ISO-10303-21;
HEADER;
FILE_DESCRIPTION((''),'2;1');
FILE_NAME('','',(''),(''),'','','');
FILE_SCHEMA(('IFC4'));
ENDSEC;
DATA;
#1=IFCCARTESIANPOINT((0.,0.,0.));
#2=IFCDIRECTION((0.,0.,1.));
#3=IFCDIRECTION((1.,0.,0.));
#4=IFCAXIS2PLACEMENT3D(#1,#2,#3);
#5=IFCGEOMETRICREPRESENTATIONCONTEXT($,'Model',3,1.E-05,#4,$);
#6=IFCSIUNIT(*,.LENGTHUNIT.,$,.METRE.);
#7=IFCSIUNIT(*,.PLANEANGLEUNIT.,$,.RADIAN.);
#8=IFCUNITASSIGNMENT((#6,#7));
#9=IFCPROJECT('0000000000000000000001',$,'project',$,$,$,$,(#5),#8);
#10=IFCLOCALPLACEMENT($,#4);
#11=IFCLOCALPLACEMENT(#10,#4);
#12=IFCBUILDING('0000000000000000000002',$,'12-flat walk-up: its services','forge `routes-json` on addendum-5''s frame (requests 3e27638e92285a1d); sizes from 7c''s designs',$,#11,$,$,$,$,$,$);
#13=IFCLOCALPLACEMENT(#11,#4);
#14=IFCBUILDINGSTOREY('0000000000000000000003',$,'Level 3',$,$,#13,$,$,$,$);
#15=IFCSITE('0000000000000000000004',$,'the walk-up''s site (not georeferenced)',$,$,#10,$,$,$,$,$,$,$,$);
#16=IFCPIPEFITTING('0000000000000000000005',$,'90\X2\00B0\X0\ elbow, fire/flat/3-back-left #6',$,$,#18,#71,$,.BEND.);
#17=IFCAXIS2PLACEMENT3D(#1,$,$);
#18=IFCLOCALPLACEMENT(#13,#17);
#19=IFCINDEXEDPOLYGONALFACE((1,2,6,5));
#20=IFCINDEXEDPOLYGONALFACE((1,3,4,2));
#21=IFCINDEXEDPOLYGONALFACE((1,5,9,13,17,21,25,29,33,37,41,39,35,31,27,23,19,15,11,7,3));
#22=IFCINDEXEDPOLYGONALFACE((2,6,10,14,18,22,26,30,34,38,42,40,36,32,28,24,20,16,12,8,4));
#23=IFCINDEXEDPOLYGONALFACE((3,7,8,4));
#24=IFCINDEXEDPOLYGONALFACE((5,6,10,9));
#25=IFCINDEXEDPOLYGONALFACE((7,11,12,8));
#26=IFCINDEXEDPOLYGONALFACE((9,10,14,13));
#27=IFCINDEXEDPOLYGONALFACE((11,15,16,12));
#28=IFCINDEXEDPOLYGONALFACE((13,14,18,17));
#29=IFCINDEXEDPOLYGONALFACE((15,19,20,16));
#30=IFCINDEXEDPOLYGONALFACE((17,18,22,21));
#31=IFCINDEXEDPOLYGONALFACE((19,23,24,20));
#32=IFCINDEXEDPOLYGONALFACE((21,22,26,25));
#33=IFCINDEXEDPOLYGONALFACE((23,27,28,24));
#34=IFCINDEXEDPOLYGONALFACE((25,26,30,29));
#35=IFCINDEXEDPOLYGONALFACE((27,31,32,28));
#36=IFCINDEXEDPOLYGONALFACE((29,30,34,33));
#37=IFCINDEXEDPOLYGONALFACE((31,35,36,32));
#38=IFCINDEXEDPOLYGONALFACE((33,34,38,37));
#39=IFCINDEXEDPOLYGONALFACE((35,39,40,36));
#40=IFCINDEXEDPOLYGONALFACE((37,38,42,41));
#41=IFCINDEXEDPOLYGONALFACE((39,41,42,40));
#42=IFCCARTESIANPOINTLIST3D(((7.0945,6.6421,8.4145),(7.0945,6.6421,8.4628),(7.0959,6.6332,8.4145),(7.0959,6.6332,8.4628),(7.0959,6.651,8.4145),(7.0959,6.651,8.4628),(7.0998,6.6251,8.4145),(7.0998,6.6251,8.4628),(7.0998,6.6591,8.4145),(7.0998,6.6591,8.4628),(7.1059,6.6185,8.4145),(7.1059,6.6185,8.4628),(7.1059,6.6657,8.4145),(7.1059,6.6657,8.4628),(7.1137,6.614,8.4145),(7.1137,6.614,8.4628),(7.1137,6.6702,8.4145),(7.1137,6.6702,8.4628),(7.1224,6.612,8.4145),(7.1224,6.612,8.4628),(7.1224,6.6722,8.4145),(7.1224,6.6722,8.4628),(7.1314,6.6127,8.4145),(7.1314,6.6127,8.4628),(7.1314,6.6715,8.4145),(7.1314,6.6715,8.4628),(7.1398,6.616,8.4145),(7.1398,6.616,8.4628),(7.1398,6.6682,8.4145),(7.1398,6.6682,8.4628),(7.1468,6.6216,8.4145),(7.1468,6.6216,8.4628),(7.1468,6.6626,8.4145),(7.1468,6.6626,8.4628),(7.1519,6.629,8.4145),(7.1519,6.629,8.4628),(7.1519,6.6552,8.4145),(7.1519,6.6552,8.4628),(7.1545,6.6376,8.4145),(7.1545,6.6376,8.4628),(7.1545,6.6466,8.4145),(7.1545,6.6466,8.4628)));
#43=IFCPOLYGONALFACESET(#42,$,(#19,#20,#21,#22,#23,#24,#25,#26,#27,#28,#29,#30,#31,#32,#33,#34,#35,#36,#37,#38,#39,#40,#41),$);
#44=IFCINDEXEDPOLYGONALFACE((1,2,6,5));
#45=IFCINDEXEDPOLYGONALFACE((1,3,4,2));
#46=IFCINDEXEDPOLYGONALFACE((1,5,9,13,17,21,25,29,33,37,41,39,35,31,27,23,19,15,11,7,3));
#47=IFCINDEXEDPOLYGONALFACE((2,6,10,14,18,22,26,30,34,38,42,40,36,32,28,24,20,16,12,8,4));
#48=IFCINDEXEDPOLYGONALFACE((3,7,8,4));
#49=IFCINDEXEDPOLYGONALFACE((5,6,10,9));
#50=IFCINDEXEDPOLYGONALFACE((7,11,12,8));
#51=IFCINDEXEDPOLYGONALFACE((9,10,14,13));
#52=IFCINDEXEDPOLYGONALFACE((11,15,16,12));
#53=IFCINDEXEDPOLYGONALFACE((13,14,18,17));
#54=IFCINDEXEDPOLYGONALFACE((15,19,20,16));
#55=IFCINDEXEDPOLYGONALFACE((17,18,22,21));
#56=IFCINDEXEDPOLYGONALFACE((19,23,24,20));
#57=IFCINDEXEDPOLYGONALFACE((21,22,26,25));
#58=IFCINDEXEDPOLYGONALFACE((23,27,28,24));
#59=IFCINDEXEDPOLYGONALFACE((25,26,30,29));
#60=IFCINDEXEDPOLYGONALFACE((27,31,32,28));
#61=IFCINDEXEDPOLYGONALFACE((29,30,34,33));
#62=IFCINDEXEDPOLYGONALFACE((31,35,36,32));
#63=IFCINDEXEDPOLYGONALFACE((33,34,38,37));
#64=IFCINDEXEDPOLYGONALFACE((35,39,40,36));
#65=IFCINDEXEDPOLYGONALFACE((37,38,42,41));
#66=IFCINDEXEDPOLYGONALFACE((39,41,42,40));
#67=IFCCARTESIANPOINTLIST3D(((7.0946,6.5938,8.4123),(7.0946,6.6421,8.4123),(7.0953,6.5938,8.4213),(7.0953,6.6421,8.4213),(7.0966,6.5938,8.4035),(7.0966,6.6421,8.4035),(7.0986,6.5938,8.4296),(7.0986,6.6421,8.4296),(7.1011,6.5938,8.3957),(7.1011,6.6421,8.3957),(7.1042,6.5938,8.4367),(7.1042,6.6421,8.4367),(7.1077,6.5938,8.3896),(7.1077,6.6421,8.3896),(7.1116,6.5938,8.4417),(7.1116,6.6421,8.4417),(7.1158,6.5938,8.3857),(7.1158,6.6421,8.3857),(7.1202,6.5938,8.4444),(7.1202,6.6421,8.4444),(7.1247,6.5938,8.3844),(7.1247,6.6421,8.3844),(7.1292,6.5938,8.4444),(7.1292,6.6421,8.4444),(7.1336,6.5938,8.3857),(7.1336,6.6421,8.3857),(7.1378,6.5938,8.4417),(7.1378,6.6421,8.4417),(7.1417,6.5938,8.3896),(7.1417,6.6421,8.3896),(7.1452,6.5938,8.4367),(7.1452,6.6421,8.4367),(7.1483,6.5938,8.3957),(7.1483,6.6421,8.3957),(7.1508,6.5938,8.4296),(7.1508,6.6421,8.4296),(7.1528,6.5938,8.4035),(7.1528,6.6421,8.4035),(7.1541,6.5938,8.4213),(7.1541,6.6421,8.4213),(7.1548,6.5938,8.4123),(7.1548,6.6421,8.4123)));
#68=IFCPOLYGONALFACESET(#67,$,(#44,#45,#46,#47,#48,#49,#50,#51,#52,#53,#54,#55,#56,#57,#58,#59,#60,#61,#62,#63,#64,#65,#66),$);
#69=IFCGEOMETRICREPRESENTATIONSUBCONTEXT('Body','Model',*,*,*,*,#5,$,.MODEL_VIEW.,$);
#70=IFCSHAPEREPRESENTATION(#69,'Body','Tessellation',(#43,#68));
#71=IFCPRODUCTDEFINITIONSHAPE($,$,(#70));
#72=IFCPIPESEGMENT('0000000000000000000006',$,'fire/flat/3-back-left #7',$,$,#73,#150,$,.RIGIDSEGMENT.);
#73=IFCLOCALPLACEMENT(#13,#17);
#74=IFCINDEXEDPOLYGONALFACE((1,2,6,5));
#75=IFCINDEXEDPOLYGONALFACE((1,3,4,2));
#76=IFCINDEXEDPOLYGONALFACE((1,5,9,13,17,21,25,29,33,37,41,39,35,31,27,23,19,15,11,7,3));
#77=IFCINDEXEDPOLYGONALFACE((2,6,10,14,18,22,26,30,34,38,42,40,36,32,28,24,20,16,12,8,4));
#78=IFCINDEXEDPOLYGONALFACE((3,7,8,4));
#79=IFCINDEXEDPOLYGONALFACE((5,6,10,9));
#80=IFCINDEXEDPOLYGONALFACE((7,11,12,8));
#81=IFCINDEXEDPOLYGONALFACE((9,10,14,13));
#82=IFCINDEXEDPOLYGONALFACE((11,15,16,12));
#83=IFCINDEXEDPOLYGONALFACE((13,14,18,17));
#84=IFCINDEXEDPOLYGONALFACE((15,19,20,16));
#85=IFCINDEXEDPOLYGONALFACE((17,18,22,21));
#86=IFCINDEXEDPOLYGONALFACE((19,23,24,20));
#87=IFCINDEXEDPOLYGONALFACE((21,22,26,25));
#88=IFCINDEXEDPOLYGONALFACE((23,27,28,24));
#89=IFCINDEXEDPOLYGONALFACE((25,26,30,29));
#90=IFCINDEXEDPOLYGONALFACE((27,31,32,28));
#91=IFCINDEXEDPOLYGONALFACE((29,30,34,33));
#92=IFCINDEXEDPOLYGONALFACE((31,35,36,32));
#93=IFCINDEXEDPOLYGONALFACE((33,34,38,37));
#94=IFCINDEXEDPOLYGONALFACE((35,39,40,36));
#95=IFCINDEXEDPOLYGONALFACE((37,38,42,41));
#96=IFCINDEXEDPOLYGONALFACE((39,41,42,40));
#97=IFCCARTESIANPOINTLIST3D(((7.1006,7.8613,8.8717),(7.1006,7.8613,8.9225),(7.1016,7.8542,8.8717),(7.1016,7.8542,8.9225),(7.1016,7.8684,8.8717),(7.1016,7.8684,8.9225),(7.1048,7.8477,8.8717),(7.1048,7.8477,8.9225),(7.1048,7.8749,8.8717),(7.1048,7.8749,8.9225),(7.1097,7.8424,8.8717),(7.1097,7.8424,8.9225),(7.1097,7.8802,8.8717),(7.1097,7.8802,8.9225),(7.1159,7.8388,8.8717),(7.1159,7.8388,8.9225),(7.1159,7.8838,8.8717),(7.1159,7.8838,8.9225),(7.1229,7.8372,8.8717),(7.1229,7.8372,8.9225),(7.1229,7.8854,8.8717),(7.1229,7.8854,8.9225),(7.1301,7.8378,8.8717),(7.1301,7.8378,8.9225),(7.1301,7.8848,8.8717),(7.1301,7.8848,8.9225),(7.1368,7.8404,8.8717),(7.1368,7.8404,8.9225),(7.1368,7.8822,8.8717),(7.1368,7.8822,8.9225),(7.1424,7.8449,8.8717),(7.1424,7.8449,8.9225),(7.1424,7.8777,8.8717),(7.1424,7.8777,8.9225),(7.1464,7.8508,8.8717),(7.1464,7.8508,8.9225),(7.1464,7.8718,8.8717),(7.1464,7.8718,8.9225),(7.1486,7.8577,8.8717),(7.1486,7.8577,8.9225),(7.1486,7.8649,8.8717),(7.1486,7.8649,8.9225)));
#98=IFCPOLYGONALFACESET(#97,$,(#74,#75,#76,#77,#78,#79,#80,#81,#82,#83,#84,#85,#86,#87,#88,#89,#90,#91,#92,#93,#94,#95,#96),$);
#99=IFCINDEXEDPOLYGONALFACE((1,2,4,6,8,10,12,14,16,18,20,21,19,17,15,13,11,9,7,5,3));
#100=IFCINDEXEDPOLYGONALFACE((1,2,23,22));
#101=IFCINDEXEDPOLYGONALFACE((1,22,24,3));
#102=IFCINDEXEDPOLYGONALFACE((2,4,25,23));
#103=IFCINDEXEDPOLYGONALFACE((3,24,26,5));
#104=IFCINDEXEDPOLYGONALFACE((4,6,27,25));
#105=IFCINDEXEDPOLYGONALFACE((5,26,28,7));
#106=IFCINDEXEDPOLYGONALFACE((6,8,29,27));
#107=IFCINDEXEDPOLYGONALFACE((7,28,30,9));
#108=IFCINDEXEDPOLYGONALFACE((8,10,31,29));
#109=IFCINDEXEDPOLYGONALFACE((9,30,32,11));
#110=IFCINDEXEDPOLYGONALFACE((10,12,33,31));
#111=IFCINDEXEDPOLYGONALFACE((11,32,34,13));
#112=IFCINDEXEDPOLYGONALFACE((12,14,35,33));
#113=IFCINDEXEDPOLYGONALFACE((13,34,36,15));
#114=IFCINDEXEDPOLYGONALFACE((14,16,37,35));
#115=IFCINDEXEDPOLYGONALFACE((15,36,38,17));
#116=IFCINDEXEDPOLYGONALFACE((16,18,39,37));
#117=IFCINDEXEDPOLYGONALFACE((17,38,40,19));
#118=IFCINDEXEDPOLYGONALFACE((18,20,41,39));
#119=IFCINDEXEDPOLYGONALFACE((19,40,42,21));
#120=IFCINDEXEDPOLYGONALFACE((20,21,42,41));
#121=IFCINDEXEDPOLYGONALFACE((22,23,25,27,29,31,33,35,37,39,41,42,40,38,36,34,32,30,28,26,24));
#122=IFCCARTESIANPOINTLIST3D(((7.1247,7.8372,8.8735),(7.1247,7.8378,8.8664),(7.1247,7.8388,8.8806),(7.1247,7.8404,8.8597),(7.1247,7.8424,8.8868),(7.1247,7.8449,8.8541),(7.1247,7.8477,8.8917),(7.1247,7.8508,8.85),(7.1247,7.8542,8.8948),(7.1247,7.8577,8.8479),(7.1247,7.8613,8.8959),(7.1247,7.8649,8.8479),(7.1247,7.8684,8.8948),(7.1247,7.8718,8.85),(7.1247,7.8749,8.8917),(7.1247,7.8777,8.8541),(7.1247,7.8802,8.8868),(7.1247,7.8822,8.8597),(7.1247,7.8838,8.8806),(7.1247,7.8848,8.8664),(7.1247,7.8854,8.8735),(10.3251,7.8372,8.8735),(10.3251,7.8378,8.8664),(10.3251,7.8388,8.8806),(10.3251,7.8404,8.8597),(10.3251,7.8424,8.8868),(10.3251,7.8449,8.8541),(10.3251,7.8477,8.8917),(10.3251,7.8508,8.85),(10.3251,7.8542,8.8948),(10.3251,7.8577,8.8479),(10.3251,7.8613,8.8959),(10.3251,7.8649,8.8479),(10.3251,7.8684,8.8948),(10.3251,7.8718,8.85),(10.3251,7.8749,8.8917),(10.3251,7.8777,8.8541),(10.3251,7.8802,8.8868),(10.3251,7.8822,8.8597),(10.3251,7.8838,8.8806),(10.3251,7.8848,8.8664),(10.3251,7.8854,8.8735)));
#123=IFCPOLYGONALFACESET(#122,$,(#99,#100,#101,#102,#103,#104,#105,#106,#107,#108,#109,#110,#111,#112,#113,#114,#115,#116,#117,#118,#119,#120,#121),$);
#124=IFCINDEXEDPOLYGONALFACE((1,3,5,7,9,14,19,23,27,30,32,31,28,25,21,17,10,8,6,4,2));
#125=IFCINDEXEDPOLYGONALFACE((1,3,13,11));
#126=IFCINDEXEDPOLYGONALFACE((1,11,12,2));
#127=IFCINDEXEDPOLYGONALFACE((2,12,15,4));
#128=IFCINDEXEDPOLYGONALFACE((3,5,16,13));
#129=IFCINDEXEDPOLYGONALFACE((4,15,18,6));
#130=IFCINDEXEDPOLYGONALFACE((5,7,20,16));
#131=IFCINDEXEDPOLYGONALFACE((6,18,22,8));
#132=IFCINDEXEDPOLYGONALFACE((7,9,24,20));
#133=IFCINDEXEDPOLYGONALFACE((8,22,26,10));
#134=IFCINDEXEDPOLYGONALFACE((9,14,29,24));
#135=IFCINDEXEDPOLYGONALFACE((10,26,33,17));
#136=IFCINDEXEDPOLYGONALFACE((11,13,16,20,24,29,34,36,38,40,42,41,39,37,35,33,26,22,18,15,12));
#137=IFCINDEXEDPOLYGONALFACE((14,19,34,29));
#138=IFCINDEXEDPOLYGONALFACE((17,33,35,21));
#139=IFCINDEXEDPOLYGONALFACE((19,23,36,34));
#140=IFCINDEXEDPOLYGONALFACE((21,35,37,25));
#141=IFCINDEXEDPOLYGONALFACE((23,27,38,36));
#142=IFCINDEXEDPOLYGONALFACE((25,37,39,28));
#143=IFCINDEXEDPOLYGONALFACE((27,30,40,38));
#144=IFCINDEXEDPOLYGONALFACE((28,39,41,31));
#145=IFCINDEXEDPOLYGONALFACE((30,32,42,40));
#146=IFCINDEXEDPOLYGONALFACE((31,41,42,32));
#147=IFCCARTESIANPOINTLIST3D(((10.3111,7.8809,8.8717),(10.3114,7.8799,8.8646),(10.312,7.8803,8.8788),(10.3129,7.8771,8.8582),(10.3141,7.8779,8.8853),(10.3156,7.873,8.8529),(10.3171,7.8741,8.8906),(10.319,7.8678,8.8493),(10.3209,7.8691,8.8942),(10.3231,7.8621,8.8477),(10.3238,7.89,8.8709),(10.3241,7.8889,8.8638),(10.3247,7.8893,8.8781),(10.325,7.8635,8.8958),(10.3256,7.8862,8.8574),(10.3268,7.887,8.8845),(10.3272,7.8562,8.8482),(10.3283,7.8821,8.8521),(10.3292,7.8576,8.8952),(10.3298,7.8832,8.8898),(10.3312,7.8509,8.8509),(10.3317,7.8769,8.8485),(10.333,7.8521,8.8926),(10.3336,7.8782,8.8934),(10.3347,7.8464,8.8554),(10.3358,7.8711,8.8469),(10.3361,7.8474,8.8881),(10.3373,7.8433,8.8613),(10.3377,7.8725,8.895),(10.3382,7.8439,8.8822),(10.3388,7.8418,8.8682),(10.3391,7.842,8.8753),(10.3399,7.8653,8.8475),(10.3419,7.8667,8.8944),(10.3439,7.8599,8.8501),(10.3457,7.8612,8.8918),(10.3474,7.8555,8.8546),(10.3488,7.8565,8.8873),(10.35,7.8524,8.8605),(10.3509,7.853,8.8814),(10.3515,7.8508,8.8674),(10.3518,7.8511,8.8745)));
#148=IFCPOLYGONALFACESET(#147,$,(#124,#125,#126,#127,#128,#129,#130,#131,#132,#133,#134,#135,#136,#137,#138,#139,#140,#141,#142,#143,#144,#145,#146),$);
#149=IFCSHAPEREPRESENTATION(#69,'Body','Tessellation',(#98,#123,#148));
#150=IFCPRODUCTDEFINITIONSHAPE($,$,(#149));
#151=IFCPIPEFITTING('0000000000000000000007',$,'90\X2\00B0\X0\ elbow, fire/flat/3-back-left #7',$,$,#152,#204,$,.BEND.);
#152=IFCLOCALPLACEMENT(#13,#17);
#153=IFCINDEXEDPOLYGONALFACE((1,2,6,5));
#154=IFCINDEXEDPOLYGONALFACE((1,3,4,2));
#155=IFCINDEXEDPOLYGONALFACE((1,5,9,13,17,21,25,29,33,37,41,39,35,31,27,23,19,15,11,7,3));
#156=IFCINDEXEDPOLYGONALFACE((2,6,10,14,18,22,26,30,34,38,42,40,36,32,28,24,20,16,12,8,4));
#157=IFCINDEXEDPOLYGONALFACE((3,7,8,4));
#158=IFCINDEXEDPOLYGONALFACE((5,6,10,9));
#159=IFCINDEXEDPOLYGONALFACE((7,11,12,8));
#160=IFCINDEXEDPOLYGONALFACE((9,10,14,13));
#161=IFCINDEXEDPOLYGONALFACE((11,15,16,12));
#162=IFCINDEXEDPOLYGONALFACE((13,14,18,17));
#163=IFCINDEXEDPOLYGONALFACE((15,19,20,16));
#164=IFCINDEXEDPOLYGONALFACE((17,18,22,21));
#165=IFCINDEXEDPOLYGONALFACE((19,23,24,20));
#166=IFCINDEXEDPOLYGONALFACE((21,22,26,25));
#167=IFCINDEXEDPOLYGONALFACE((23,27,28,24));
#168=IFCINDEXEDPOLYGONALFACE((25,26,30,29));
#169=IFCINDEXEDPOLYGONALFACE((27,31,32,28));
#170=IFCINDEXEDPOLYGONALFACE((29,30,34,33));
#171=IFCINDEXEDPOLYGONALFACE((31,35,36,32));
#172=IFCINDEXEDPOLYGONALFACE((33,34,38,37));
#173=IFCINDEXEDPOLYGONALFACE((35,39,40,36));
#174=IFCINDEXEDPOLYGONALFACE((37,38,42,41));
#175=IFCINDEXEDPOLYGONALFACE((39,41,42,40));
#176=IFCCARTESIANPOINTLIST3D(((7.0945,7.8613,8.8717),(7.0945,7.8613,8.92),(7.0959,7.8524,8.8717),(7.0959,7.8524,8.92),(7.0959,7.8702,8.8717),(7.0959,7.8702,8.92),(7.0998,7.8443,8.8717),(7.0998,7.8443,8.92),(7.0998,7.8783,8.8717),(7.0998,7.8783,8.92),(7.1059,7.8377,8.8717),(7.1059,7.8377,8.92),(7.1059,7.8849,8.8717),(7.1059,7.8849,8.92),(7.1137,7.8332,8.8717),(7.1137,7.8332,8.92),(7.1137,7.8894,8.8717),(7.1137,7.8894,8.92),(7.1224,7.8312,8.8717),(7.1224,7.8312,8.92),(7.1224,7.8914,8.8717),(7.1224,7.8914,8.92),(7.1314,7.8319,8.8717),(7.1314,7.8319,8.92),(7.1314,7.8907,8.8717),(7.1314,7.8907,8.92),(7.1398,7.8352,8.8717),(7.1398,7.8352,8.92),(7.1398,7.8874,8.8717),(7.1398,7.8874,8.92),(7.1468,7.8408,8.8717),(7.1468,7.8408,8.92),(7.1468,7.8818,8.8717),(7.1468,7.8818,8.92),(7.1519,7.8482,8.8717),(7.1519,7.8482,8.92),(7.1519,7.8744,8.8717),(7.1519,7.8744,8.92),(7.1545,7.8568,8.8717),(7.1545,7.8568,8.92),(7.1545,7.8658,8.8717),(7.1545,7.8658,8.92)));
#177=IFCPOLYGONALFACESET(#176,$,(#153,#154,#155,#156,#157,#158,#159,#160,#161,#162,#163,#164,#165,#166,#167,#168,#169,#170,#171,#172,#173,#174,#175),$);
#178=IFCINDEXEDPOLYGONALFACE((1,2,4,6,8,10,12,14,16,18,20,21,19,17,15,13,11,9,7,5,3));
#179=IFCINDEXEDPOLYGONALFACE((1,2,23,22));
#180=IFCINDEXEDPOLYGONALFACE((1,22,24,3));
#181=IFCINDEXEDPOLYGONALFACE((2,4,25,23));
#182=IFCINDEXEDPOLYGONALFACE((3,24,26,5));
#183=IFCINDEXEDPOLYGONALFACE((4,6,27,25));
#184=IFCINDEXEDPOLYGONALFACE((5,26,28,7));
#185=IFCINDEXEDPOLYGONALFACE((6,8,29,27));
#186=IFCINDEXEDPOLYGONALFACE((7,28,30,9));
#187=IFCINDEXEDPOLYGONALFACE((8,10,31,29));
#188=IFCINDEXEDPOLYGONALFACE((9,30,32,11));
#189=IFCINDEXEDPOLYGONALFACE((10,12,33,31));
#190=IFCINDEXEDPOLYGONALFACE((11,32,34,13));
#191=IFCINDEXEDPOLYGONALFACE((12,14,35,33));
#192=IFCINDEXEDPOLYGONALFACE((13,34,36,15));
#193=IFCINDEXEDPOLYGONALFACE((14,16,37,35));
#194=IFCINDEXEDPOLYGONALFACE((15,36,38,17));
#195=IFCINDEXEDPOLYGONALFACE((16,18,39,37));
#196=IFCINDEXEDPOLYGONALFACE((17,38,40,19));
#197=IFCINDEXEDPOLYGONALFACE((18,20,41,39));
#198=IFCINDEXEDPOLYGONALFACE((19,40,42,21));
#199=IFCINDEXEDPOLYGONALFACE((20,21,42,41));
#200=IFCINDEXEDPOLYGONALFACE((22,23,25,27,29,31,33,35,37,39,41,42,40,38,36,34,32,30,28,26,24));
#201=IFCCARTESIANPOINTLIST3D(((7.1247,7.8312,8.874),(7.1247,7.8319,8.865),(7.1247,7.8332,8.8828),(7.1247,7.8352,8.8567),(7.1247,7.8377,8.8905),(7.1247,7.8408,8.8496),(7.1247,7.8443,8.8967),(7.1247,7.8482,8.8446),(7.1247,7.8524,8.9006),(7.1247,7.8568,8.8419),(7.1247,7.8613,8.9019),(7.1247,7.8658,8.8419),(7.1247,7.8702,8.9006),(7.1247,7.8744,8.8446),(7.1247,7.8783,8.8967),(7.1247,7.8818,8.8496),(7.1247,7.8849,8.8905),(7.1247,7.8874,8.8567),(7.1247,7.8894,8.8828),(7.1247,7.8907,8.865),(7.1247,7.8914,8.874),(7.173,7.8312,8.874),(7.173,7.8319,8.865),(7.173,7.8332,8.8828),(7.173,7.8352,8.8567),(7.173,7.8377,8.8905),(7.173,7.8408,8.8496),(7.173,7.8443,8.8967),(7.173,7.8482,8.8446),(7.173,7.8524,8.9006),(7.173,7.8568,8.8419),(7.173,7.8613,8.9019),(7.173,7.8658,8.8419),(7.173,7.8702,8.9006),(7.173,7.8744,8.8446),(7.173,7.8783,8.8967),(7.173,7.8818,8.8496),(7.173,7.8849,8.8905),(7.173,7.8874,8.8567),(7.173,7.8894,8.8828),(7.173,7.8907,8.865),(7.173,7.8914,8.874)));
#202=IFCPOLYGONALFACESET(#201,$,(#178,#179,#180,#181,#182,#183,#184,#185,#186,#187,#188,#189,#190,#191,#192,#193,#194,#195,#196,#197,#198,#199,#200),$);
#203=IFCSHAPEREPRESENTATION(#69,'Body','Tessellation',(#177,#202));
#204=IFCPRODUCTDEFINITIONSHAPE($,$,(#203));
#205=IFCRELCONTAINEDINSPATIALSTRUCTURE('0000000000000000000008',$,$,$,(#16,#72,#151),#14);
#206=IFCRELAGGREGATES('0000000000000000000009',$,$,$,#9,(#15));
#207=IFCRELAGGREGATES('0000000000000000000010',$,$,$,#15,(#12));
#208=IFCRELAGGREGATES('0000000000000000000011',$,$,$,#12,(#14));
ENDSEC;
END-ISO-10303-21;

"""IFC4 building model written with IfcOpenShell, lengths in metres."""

from ifc_helpers import new_model, entity, si_unit, frame, origin_with_axes, place, context, subcontext, project, spatial, element, save


model = new_model("IFC4")

# Units and contexts
model_context = context("Model", 3, precision=1e-05, world=origin_with_axes())
body_context = subcontext(model_context, "Body", "Model", "MODEL_VIEW")
ifc_project = project(units=[si_unit("LENGTHUNIT", "METRE"), si_unit("PLANEANGLEUNIT", "RADIAN")], contexts=[model_context])

# Site, building, storey
site_placement = place(None, origin_with_axes())
site = spatial("IfcSite", under=ifc_project, at=site_placement, Name="the walk-up's site (not georeferenced)")
building_placement = place(site_placement, origin_with_axes())
building = spatial("IfcBuilding", under=site, at=building_placement, Name="12-flat walk-up: its services", Description="forge `routes-json` on addendum-5's frame (requests 3e27638e92285a1d); sizes from 7c's designs")
storey_placement = place(building_placement, origin_with_axes())
storey = spatial("IfcBuildingStorey", under=building, at=storey_placement, Name="Level 3")

# Pipe fitting
pipe_fitting_1_placement = place(storey_placement, frame((7.1247, 6.6421, 8.4628), z_axis=(0.0, 0.0, 1.0), x_axis=(1.0, 0.0, 0.0)))
element("IfcPipeFitting", 1, at=pipe_fitting_1_placement, inside=storey, Name="90° elbow, fire/flat/3-back-left #6", PredefinedType="BEND", context=body_context, shape_type="AdvancedSweptSolid", body=[
    entity("IfcSweptDiskSolid", entity("IfcPolyline", [entity("IfcCartesianPoint", [0.0, 0.0, 0.0]), entity("IfcCartesianPoint", [0.0, 0.0, -0.0483])]), 0.0302),
    entity("IfcSweptDiskSolid", entity("IfcPolyline", [entity("IfcCartesianPoint", [0.0, 0.0, -0.0483]), entity("IfcCartesianPoint", [0.0, -0.0483, -0.0483])]), 0.0302),
])

# Pipe segment
pipe_segment_1_placement = place(storey_placement, frame((7.1247, 7.8613, 8.9225), z_axis=(0.0, 0.0, 1.0), x_axis=(1.0, 0.0, 0.0)))
element("IfcPipeSegment", 2, at=pipe_segment_1_placement, inside=storey, Name="fire/flat/3-back-left #7", PredefinedType="RIGIDSEGMENT", context=body_context, shape_type="AdvancedSweptSolid", body=[
    entity("IfcSweptDiskSolid", entity("IfcPolyline", [entity("IfcCartesianPoint", [0.0, 0.0, 0.0]), entity("IfcCartesianPoint", [0.0, 0.0, -0.0508])]), 0.0241),
    entity("IfcSweptDiskSolid", entity("IfcPolyline", [entity("IfcCartesianPoint", [0.0, 0.0, -0.0508]), entity("IfcCartesianPoint", [3.2004, 0.0, -0.0508])]), 0.0241),
    entity("IfcSweptDiskSolid", entity("IfcPolyline", [entity("IfcCartesianPoint", [3.2004, 0.0, -0.0508]), entity("IfcCartesianPoint", [3.2131, 0.0091, -0.0516])]), 0.0241),
])

# Pipe fitting
pipe_fitting_2_placement = place(storey_placement, frame((7.1247, 7.8613, 8.92), z_axis=(0.0, 0.0, 1.0), x_axis=(1.0, 0.0, 0.0)))
element("IfcPipeFitting", 3, at=pipe_fitting_2_placement, inside=storey, Name="90° elbow, fire/flat/3-back-left #7", PredefinedType="BEND", context=body_context, shape_type="AdvancedSweptSolid", body=[
    entity("IfcSweptDiskSolid", entity("IfcPolyline", [entity("IfcCartesianPoint", [0.0, 0.0, 0.0]), entity("IfcCartesianPoint", [0.0, 0.0, -0.0483])]), 0.0302),
    entity("IfcSweptDiskSolid", entity("IfcPolyline", [entity("IfcCartesianPoint", [0.0, 0.0, -0.0483]), entity("IfcCartesianPoint", [0.0483, 0.0, -0.0483])]), 0.0302),
])

save(model, "model.ifc")
